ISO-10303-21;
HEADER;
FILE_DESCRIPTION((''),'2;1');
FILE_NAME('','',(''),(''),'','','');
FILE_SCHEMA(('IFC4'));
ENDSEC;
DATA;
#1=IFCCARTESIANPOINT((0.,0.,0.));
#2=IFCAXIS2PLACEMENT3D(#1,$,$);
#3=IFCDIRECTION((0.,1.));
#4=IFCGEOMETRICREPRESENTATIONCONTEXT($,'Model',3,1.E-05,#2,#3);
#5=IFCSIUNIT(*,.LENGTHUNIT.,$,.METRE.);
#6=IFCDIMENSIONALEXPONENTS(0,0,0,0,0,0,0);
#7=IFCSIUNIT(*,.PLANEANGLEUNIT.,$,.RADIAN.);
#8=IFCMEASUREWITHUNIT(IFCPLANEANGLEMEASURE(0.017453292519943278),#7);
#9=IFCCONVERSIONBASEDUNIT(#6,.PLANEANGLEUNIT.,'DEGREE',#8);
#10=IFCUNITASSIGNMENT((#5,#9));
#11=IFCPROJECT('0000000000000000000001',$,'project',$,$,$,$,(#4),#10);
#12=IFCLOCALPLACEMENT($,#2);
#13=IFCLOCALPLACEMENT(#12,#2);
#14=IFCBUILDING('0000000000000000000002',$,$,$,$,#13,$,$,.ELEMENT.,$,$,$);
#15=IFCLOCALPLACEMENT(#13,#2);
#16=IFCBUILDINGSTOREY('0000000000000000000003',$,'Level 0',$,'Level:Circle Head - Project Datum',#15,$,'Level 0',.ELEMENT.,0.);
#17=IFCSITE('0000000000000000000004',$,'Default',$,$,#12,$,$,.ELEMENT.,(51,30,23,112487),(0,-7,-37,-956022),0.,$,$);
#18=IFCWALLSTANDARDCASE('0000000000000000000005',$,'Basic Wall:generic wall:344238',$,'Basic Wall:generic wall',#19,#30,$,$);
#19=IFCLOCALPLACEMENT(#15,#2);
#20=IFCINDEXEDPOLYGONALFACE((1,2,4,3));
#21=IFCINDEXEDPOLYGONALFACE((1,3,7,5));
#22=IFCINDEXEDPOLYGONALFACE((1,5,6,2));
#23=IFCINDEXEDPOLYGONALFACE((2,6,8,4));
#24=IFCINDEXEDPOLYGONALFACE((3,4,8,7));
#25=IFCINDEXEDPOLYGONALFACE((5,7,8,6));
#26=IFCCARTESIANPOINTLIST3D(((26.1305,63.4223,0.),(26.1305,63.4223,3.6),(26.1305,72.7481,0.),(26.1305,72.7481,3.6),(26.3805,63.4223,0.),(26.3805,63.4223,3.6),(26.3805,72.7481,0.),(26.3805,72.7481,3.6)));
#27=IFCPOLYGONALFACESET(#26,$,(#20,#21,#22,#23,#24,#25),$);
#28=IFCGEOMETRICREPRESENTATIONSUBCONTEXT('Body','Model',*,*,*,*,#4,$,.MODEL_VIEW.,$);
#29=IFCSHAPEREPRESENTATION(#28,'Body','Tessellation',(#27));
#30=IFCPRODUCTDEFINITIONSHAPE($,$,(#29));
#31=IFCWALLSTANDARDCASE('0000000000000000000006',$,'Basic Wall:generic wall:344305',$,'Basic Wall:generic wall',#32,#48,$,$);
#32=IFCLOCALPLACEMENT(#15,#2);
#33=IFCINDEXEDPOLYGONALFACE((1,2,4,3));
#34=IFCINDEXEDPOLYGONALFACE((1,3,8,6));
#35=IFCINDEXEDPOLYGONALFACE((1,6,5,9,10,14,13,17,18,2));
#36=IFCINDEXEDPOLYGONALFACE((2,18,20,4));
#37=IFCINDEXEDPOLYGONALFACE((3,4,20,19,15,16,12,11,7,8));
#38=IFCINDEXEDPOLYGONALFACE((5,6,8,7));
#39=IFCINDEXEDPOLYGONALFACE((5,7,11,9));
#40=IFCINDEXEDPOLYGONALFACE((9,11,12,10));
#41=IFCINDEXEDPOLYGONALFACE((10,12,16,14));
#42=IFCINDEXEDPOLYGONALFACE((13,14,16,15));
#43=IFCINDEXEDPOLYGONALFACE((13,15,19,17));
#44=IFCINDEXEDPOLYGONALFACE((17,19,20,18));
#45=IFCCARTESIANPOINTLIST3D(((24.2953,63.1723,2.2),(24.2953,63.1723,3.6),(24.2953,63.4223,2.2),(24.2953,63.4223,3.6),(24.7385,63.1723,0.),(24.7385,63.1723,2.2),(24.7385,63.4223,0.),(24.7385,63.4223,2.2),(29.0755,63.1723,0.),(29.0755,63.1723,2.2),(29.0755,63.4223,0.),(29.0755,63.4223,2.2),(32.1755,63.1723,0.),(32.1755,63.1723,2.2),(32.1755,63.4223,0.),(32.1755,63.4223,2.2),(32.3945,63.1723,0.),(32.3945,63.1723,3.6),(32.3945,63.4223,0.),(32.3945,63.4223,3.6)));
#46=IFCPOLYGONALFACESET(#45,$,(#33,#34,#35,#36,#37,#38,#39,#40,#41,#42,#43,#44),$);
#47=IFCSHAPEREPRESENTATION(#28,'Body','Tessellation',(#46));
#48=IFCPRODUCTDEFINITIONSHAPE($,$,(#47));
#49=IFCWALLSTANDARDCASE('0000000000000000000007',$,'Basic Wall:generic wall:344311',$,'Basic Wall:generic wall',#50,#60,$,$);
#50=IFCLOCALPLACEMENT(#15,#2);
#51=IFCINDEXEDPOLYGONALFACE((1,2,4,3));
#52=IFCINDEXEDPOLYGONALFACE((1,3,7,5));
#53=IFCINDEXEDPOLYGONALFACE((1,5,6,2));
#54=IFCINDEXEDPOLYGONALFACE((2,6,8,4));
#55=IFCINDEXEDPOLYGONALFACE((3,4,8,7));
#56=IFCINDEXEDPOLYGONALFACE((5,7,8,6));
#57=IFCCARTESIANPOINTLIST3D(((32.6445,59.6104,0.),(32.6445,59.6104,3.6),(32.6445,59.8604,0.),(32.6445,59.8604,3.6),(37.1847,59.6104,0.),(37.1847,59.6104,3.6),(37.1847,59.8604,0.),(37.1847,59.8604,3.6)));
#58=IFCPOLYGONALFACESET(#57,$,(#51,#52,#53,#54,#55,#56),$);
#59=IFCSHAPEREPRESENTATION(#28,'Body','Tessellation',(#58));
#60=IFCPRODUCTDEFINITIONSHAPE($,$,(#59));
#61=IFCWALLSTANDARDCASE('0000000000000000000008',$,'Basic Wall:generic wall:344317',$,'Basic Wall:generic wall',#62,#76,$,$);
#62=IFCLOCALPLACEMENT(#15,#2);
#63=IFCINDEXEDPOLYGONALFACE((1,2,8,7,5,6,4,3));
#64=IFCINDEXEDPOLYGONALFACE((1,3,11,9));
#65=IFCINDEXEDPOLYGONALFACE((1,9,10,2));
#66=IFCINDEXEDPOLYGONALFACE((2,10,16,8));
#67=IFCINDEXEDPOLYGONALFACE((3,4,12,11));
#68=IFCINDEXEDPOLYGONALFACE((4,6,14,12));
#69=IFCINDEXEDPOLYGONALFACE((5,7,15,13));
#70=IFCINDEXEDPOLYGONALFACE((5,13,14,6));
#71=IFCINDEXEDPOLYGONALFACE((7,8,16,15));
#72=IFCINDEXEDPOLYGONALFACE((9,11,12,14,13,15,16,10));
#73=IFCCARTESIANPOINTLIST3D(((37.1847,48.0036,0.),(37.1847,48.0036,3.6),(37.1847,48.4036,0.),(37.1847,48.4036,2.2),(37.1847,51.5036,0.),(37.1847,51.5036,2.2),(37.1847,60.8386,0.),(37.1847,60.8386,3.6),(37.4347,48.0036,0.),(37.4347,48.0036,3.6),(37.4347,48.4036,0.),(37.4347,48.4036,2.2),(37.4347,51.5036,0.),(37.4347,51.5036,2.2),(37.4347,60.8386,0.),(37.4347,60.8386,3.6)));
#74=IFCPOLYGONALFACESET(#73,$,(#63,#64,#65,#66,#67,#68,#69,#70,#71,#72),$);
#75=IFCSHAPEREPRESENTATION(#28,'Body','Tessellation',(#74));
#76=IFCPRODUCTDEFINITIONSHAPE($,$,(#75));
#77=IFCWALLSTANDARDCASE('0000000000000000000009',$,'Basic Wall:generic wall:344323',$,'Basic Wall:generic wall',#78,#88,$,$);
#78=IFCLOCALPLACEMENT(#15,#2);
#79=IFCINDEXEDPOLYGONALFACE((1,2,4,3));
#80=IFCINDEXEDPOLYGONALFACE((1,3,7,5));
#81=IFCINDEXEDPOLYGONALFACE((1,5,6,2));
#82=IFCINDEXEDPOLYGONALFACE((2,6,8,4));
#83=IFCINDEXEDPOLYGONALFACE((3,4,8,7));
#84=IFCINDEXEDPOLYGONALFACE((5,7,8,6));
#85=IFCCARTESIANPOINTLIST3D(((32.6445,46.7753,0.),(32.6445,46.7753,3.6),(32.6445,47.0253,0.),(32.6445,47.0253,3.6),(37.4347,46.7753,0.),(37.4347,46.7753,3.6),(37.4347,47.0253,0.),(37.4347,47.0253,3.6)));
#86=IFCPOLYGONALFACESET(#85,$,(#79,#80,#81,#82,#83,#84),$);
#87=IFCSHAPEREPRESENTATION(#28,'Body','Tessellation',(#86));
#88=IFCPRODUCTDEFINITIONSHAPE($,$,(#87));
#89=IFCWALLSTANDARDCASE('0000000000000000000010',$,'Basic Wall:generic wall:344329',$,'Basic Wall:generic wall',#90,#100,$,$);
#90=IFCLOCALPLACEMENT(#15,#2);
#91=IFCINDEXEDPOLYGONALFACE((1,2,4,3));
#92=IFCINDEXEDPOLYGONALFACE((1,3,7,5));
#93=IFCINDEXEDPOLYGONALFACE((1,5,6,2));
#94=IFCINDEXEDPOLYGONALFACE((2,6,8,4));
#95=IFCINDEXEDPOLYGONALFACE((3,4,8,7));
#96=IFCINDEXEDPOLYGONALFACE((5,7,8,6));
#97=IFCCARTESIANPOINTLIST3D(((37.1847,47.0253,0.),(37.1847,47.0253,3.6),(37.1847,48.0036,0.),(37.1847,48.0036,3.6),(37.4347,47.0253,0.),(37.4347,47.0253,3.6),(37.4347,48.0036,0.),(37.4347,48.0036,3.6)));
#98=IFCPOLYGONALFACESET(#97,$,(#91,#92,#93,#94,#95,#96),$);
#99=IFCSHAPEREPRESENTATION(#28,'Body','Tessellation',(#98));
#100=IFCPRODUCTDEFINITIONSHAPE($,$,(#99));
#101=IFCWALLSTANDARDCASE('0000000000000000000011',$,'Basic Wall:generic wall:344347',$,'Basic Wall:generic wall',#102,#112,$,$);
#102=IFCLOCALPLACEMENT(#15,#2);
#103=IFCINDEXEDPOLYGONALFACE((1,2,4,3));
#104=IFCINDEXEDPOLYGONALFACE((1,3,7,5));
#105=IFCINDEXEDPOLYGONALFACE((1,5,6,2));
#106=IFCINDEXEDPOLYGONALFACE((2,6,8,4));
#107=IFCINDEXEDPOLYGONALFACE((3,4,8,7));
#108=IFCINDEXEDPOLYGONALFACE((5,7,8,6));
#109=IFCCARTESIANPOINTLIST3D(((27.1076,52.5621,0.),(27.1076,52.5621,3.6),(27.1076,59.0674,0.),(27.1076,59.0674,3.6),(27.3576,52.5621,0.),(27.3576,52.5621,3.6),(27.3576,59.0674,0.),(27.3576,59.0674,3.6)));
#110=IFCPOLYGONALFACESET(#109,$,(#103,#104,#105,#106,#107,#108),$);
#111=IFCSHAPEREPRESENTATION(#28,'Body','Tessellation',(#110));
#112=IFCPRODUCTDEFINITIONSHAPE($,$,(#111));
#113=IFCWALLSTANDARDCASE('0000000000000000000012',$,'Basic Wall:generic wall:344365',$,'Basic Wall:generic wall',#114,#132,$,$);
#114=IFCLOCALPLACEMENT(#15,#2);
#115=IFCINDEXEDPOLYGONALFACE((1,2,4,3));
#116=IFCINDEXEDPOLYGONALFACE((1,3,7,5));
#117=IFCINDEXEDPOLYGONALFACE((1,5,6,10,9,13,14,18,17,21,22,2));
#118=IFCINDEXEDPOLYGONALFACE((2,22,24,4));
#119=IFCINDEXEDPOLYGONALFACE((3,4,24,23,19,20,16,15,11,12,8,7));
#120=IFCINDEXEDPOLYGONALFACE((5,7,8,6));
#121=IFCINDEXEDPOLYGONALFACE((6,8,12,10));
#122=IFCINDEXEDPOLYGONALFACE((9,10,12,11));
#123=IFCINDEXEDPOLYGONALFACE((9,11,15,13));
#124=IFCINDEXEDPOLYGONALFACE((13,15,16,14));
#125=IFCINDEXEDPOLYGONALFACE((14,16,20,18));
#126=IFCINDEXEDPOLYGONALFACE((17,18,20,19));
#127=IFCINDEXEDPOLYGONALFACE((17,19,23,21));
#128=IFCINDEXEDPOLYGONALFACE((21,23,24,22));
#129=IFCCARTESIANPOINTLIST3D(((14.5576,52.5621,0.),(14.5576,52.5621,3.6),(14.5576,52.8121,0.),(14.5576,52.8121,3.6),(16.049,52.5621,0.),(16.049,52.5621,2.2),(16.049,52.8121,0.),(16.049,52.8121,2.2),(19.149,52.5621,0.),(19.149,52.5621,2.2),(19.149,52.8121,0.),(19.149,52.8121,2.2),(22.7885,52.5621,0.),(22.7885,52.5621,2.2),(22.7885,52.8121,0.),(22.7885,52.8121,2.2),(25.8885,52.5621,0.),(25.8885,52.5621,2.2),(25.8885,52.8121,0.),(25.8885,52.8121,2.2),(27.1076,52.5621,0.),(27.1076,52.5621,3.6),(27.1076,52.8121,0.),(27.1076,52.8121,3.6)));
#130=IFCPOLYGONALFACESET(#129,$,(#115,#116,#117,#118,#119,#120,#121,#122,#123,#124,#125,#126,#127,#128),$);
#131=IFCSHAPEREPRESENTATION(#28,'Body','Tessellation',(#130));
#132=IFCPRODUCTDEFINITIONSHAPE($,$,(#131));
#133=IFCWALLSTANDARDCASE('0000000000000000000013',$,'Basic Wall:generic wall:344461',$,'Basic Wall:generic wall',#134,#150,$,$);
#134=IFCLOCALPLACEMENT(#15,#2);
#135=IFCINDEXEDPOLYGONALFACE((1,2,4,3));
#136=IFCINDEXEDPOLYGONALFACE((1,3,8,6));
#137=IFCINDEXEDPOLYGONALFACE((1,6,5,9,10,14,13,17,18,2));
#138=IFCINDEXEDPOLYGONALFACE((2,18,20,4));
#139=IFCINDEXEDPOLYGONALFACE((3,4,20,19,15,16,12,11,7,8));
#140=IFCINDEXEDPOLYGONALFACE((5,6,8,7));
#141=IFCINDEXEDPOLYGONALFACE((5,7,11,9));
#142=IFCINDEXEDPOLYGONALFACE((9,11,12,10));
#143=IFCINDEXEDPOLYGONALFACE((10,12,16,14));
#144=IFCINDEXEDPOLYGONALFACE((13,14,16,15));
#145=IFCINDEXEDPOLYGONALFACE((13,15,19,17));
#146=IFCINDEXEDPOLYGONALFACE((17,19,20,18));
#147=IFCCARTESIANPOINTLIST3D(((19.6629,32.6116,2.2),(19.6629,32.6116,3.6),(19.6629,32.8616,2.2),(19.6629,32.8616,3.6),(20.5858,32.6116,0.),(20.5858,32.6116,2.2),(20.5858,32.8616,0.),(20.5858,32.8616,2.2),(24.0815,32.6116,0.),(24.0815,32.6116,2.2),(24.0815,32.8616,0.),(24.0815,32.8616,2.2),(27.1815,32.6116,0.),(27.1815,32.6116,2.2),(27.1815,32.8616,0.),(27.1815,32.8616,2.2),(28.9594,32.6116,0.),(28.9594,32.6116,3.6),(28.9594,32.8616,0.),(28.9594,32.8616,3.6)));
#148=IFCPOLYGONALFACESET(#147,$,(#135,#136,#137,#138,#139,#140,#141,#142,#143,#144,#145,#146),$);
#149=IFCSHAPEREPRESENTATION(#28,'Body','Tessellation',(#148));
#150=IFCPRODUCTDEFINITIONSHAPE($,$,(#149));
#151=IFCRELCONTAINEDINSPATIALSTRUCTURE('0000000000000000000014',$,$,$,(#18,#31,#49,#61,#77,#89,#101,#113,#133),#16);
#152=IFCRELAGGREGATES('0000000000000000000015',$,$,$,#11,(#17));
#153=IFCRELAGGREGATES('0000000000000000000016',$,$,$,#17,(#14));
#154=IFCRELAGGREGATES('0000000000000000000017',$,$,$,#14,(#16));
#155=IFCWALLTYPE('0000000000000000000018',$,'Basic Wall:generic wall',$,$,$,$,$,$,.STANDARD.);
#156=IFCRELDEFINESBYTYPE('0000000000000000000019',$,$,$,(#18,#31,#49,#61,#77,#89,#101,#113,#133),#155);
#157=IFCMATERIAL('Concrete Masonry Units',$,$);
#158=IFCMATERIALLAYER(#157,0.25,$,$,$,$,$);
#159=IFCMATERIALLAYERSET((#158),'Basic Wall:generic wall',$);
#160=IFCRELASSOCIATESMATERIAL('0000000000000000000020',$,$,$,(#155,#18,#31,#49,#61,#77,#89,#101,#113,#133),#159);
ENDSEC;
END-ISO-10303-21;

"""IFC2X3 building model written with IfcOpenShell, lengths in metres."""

from ifc_helpers import new_model, entity, si_unit, converted_unit, direction, frame, frame_2d, origin, origin_2d_with_axis, place, context, subcontext, project, spatial, rectangle, extrude, material, layer, layer_set, layer_usage, type_object, element, save


model = new_model("IFC2X3")

# Units and contexts
model_context = context("Model", 3, precision=1e-05, world=origin(), true_north=direction((0.0, 1.0)))
body_context = subcontext(model_context, "Body", "Model", "MODEL_VIEW")
ifc_project = project(units=[si_unit("LENGTHUNIT", "METRE"), converted_unit("PLANEANGLEUNIT", "DEGREE", entity("IfcPlaneAngleMeasure", 0.017453292519943278), si_unit("PLANEANGLEUNIT", "RADIAN"), dimensions=[0, 0, 0, 0, 0, 0, 0])], contexts=[model_context])

# Site, building, storey
site_placement = place(None, origin())
site = spatial("IfcSite", under=ifc_project, at=site_placement, Name="Default", CompositionType="ELEMENT", RefLatitude=(51, 30, 23, 112487), RefLongitude=(0, -7, -37, -956022), RefElevation=0.0)
building_placement = place(site_placement, origin())
building = spatial("IfcBuilding", under=site, at=building_placement, CompositionType="ELEMENT")
storey_placement = place(building_placement, origin())
storey = spatial("IfcBuildingStorey", under=building, at=storey_placement, Name="Level 0", ObjectType="Level:Circle Head - Project Datum", LongName="Level 0", CompositionType="ELEMENT", Elevation=0.0)

# Shared definitions
ifc_material = material(Name="Concrete Masonry Units")
ifc_layer = layer(ifc_material, 0.25)
ifc_layer_set = layer_set([ifc_layer], Name="Basic Wall:generic wall")
wall_type = type_object("IfcWallType", Name="Basic Wall:generic wall", PredefinedType="STANDARD", material=ifc_layer_set)

# Wall
ifc_layer_usage_1 = layer_usage(ifc_layer_set, "AXIS2", "NEGATIVE", 0.125)
wall_1_placement = place(storey_placement, frame((26.2555, 72.7481, 0.0), z_axis=(0.0, 0.0, 1.0), x_axis=(0.0, -1.0, 0.0)))
element("IfcWallStandardCase", 1, at=wall_1_placement, inside=storey, type_object=wall_type, material=ifc_layer_usage_1, Name="Basic Wall:generic wall:344238", ObjectType="Basic Wall:generic wall", context=body_context, shape_type="SweptSolid", body=[
    extrude(rectangle(XDim=9.3259, YDim=0.25, at=frame_2d((4.6629, 0.0), x_axis=(-1.0, 0.0))), origin(), (0.0, 0.0, 1.0), 3.6),
])

# Wall, openings
ifc_layer_usage_2 = layer_usage(ifc_layer_set, "AXIS2", "NEGATIVE", 0.125)
wall_2_placement = place(storey_placement, frame((32.3945, 63.2973, 0.0), z_axis=(0.0, 0.0, 1.0), x_axis=(-1.0, 0.0, 0.0)))
wall_2 = element("IfcWallStandardCase", 2, at=wall_2_placement, inside=storey, type_object=wall_type, material=ifc_layer_usage_2, Name="Basic Wall:generic wall:344305", ObjectType="Basic Wall:generic wall", context=body_context, shape_type="SweptSolid", body=[
    extrude(rectangle(XDim=8.0993, YDim=0.25, at=frame_2d((4.0496, 0.0), x_axis=(1.0, 0.0))), origin(), (0.0, 0.0, 1.0), 3.6),
])
opening_1_placement = place(wall_2_placement, origin())
element("IfcOpeningElement", 3, at=opening_1_placement, cuts=wall_2, ObjectType="Opening", context=body_context, shape_type="SweptSolid", body=[
    extrude(rectangle(XDim=2.2, YDim=3.1, at=origin_2d_with_axis()), frame((9.206, -1.399, 1.1), z_axis=(0.0, 1.0, 0.0), x_axis=(0.0, 0.0, 1.0)), (0.0, 0.0, 1.0), 3.048),
])
opening_2_placement = place(wall_2_placement, frame((3.3191, 0.125, 0.0)))
element("IfcOpeningElement", 4, at=opening_2_placement, cuts=wall_2, ObjectType="Opening", context=body_context, shape_type="SweptSolid", body=[
    extrude(rectangle(XDim=2.2, YDim=3.1, at=frame_2d((1.1, 1.55), x_axis=(1.0, 0.0))), frame((0.0, 0.0, 0.0), z_axis=(0.0, -1.0, 0.0), x_axis=(0.0, 0.0, 1.0)), (0.0, 0.0, 1.0), 0.25),
])

# Wall
ifc_layer_usage_3 = layer_usage(ifc_layer_set, "AXIS2", "NEGATIVE", 0.125)
wall_3_placement = place(storey_placement, frame((37.1847, 59.7354, 0.0), z_axis=(0.0, 0.0, 1.0), x_axis=(-1.0, 0.0, 0.0)))
element("IfcWallStandardCase", 5, at=wall_3_placement, inside=storey, type_object=wall_type, material=ifc_layer_usage_3, Name="Basic Wall:generic wall:344311", ObjectType="Basic Wall:generic wall", context=body_context, shape_type="SweptSolid", body=[
    extrude(rectangle(XDim=4.5401, YDim=0.25, at=frame_2d((2.2701, 0.0), x_axis=(-1.0, 0.0))), origin(), (0.0, 0.0, 1.0), 3.6),
])

# Wall, opening
ifc_layer_usage_4 = layer_usage(ifc_layer_set, "AXIS2", "NEGATIVE", 0.125)
wall_4_placement = place(storey_placement, frame((37.3097, 48.0036, 0.0), z_axis=(0.0, 0.0, 1.0), x_axis=(0.0, 1.0, 0.0)))
wall_4 = element("IfcWallStandardCase", 6, at=wall_4_placement, inside=storey, type_object=wall_type, material=ifc_layer_usage_4, Name="Basic Wall:generic wall:344317", ObjectType="Basic Wall:generic wall", context=body_context, shape_type="SweptSolid", body=[
    extrude(rectangle(XDim=12.8351, YDim=0.25, at=frame_2d((6.4175, 0.0), x_axis=(-1.0, 0.0))), origin(), (0.0, 0.0, 1.0), 3.6),
])
opening_3_placement = place(wall_4_placement, frame((0.4, -0.125, 0.0)))
element("IfcOpeningElement", 7, at=opening_3_placement, cuts=wall_4, ObjectType="Opening", context=body_context, shape_type="SweptSolid", body=[
    extrude(rectangle(XDim=2.2, YDim=3.1, at=frame_2d((1.1, 1.55), x_axis=(1.0, 0.0))), frame((0.0, 0.0, 0.0), z_axis=(0.0, 1.0, 0.0), x_axis=(0.0, 0.0, 1.0)), (0.0, 0.0, 1.0), 0.25),
])

# Walls
ifc_layer_usage_5 = layer_usage(ifc_layer_set, "AXIS2", "NEGATIVE", 0.125)
wall_5_placement = place(storey_placement, frame((37.4347, 46.9003, 0.0), z_axis=(0.0, 0.0, 1.0), x_axis=(-1.0, 0.0, 0.0)))
element("IfcWallStandardCase", 8, at=wall_5_placement, inside=storey, type_object=wall_type, material=ifc_layer_usage_5, Name="Basic Wall:generic wall:344323", ObjectType="Basic Wall:generic wall", context=body_context, shape_type="SweptSolid", body=[
    extrude(rectangle(XDim=4.7901, YDim=0.25, at=frame_2d((2.3951, 0.0), x_axis=(-1.0, 0.0))), origin(), (0.0, 0.0, 1.0), 3.6),
])
ifc_layer_usage_6 = layer_usage(ifc_layer_set, "AXIS2", "NEGATIVE", 0.125)
wall_6_placement = place(storey_placement, frame((37.3097, 48.0036, 0.0), z_axis=(0.0, 0.0, 1.0), x_axis=(0.0, -1.0, 0.0)))
element("IfcWallStandardCase", 9, at=wall_6_placement, inside=storey, type_object=wall_type, material=ifc_layer_usage_6, Name="Basic Wall:generic wall:344329", ObjectType="Basic Wall:generic wall", context=body_context, shape_type="SweptSolid", body=[
    extrude(rectangle(XDim=0.9782, YDim=0.25, at=frame_2d((0.4891, 0.0), x_axis=(-1.0, 0.0))), origin(), (0.0, 0.0, 1.0), 3.6),
])
ifc_layer_usage_7 = layer_usage(ifc_layer_set, "AXIS2", "NEGATIVE", 0.125)
wall_7_placement = place(storey_placement, frame((27.2326, 59.0674, 0.0), z_axis=(0.0, 0.0, 1.0), x_axis=(0.0, -1.0, 0.0)))
element("IfcWallStandardCase", 10, at=wall_7_placement, inside=storey, type_object=wall_type, material=ifc_layer_usage_7, Name="Basic Wall:generic wall:344347", ObjectType="Basic Wall:generic wall", context=body_context, shape_type="SweptSolid", body=[
    extrude(rectangle(XDim=6.5053, YDim=0.25, at=frame_2d((3.2526, 0.0), x_axis=(-1.0, 0.0))), origin(), (0.0, 0.0, 1.0), 3.6),
])

# Walls, openings
ifc_layer_usage_8 = layer_usage(ifc_layer_set, "AXIS2", "NEGATIVE", 0.125)
wall_8_placement = place(storey_placement, frame((27.1076, 52.6871, 0.0), z_axis=(0.0, 0.0, 1.0), x_axis=(-1.0, 0.0, 0.0)))
wall_8 = element("IfcWallStandardCase", 11, at=wall_8_placement, inside=storey, type_object=wall_type, material=ifc_layer_usage_8, Name="Basic Wall:generic wall:344365", ObjectType="Basic Wall:generic wall", context=body_context, shape_type="SweptSolid", body=[
    extrude(rectangle(XDim=12.55, YDim=0.25, at=frame_2d((6.275, 0.0), x_axis=(1.0, 0.0))), origin(), (0.0, 0.0, 1.0), 3.6),
])
opening_4_placement = place(wall_8_placement, frame((11.0586, 0.125, 0.0)))
element("IfcOpeningElement", 12, at=opening_4_placement, cuts=wall_8, ObjectType="Opening", context=body_context, shape_type="SweptSolid", body=[
    extrude(rectangle(XDim=2.2, YDim=3.1, at=frame_2d((1.1, 1.55), x_axis=(1.0, 0.0))), frame((0.0, 0.0, 0.0), z_axis=(0.0, -1.0, 0.0), x_axis=(0.0, 0.0, 1.0)), (0.0, 0.0, 1.0), 0.25),
])
opening_5_placement = place(wall_8_placement, frame((4.319, 0.125, 0.0)))
element("IfcOpeningElement", 13, at=opening_5_placement, cuts=wall_8, ObjectType="Opening", context=body_context, shape_type="SweptSolid", body=[
    extrude(rectangle(XDim=2.2, YDim=3.1, at=frame_2d((1.1, 1.55), x_axis=(1.0, 0.0))), frame((0.0, 0.0, 0.0), z_axis=(0.0, -1.0, 0.0), x_axis=(0.0, 0.0, 1.0)), (0.0, 0.0, 1.0), 0.25),
])
ifc_layer_usage_9 = layer_usage(ifc_layer_set, "AXIS2", "NEGATIVE", 0.125)
wall_9_placement = place(storey_placement, frame((28.9594, 32.7366, 0.0), z_axis=(0.0, 0.0, 1.0), x_axis=(-1.0, 0.0, 0.0)))
wall_9 = element("IfcWallStandardCase", 14, at=wall_9_placement, inside=storey, type_object=wall_type, material=ifc_layer_usage_9, Name="Basic Wall:generic wall:344461", ObjectType="Basic Wall:generic wall", context=body_context, shape_type="SweptSolid", body=[
    extrude(rectangle(XDim=9.2965, YDim=0.25, at=frame_2d((4.6483, 0.0), x_axis=(-1.0, 0.0))), origin(), (0.0, 0.0, 1.0), 3.6),
])
opening_6_placement = place(wall_9_placement, origin())
element("IfcOpeningElement", 15, at=opening_6_placement, cuts=wall_9, ObjectType="Opening", context=body_context, shape_type="SweptSolid", body=[
    extrude(rectangle(XDim=2.2, YDim=3.1, at=frame_2d((0.0, 0.0), x_axis=(1.0, 0.0))), frame((9.9236, -1.399, 1.1), z_axis=(0.0, 1.0, 0.0), x_axis=(0.0, 0.0, 1.0)), (0.0, 0.0, 1.0), 3.048),
])
opening_7_placement = place(wall_9_placement, frame((4.8779, 0.125, 0.0)))
element("IfcOpeningElement", 16, at=opening_7_placement, cuts=wall_9, ObjectType="Opening", context=body_context, shape_type="SweptSolid", body=[
    extrude(rectangle(XDim=2.2, YDim=3.1, at=frame_2d((1.1, 1.55), x_axis=(1.0, 0.0))), frame((0.0, 0.0, 0.0), z_axis=(0.0, -1.0, 0.0), x_axis=(0.0, 0.0, 1.0)), (0.0, 0.0, 1.0), 0.25),
])

save(model, "model.ifc")
